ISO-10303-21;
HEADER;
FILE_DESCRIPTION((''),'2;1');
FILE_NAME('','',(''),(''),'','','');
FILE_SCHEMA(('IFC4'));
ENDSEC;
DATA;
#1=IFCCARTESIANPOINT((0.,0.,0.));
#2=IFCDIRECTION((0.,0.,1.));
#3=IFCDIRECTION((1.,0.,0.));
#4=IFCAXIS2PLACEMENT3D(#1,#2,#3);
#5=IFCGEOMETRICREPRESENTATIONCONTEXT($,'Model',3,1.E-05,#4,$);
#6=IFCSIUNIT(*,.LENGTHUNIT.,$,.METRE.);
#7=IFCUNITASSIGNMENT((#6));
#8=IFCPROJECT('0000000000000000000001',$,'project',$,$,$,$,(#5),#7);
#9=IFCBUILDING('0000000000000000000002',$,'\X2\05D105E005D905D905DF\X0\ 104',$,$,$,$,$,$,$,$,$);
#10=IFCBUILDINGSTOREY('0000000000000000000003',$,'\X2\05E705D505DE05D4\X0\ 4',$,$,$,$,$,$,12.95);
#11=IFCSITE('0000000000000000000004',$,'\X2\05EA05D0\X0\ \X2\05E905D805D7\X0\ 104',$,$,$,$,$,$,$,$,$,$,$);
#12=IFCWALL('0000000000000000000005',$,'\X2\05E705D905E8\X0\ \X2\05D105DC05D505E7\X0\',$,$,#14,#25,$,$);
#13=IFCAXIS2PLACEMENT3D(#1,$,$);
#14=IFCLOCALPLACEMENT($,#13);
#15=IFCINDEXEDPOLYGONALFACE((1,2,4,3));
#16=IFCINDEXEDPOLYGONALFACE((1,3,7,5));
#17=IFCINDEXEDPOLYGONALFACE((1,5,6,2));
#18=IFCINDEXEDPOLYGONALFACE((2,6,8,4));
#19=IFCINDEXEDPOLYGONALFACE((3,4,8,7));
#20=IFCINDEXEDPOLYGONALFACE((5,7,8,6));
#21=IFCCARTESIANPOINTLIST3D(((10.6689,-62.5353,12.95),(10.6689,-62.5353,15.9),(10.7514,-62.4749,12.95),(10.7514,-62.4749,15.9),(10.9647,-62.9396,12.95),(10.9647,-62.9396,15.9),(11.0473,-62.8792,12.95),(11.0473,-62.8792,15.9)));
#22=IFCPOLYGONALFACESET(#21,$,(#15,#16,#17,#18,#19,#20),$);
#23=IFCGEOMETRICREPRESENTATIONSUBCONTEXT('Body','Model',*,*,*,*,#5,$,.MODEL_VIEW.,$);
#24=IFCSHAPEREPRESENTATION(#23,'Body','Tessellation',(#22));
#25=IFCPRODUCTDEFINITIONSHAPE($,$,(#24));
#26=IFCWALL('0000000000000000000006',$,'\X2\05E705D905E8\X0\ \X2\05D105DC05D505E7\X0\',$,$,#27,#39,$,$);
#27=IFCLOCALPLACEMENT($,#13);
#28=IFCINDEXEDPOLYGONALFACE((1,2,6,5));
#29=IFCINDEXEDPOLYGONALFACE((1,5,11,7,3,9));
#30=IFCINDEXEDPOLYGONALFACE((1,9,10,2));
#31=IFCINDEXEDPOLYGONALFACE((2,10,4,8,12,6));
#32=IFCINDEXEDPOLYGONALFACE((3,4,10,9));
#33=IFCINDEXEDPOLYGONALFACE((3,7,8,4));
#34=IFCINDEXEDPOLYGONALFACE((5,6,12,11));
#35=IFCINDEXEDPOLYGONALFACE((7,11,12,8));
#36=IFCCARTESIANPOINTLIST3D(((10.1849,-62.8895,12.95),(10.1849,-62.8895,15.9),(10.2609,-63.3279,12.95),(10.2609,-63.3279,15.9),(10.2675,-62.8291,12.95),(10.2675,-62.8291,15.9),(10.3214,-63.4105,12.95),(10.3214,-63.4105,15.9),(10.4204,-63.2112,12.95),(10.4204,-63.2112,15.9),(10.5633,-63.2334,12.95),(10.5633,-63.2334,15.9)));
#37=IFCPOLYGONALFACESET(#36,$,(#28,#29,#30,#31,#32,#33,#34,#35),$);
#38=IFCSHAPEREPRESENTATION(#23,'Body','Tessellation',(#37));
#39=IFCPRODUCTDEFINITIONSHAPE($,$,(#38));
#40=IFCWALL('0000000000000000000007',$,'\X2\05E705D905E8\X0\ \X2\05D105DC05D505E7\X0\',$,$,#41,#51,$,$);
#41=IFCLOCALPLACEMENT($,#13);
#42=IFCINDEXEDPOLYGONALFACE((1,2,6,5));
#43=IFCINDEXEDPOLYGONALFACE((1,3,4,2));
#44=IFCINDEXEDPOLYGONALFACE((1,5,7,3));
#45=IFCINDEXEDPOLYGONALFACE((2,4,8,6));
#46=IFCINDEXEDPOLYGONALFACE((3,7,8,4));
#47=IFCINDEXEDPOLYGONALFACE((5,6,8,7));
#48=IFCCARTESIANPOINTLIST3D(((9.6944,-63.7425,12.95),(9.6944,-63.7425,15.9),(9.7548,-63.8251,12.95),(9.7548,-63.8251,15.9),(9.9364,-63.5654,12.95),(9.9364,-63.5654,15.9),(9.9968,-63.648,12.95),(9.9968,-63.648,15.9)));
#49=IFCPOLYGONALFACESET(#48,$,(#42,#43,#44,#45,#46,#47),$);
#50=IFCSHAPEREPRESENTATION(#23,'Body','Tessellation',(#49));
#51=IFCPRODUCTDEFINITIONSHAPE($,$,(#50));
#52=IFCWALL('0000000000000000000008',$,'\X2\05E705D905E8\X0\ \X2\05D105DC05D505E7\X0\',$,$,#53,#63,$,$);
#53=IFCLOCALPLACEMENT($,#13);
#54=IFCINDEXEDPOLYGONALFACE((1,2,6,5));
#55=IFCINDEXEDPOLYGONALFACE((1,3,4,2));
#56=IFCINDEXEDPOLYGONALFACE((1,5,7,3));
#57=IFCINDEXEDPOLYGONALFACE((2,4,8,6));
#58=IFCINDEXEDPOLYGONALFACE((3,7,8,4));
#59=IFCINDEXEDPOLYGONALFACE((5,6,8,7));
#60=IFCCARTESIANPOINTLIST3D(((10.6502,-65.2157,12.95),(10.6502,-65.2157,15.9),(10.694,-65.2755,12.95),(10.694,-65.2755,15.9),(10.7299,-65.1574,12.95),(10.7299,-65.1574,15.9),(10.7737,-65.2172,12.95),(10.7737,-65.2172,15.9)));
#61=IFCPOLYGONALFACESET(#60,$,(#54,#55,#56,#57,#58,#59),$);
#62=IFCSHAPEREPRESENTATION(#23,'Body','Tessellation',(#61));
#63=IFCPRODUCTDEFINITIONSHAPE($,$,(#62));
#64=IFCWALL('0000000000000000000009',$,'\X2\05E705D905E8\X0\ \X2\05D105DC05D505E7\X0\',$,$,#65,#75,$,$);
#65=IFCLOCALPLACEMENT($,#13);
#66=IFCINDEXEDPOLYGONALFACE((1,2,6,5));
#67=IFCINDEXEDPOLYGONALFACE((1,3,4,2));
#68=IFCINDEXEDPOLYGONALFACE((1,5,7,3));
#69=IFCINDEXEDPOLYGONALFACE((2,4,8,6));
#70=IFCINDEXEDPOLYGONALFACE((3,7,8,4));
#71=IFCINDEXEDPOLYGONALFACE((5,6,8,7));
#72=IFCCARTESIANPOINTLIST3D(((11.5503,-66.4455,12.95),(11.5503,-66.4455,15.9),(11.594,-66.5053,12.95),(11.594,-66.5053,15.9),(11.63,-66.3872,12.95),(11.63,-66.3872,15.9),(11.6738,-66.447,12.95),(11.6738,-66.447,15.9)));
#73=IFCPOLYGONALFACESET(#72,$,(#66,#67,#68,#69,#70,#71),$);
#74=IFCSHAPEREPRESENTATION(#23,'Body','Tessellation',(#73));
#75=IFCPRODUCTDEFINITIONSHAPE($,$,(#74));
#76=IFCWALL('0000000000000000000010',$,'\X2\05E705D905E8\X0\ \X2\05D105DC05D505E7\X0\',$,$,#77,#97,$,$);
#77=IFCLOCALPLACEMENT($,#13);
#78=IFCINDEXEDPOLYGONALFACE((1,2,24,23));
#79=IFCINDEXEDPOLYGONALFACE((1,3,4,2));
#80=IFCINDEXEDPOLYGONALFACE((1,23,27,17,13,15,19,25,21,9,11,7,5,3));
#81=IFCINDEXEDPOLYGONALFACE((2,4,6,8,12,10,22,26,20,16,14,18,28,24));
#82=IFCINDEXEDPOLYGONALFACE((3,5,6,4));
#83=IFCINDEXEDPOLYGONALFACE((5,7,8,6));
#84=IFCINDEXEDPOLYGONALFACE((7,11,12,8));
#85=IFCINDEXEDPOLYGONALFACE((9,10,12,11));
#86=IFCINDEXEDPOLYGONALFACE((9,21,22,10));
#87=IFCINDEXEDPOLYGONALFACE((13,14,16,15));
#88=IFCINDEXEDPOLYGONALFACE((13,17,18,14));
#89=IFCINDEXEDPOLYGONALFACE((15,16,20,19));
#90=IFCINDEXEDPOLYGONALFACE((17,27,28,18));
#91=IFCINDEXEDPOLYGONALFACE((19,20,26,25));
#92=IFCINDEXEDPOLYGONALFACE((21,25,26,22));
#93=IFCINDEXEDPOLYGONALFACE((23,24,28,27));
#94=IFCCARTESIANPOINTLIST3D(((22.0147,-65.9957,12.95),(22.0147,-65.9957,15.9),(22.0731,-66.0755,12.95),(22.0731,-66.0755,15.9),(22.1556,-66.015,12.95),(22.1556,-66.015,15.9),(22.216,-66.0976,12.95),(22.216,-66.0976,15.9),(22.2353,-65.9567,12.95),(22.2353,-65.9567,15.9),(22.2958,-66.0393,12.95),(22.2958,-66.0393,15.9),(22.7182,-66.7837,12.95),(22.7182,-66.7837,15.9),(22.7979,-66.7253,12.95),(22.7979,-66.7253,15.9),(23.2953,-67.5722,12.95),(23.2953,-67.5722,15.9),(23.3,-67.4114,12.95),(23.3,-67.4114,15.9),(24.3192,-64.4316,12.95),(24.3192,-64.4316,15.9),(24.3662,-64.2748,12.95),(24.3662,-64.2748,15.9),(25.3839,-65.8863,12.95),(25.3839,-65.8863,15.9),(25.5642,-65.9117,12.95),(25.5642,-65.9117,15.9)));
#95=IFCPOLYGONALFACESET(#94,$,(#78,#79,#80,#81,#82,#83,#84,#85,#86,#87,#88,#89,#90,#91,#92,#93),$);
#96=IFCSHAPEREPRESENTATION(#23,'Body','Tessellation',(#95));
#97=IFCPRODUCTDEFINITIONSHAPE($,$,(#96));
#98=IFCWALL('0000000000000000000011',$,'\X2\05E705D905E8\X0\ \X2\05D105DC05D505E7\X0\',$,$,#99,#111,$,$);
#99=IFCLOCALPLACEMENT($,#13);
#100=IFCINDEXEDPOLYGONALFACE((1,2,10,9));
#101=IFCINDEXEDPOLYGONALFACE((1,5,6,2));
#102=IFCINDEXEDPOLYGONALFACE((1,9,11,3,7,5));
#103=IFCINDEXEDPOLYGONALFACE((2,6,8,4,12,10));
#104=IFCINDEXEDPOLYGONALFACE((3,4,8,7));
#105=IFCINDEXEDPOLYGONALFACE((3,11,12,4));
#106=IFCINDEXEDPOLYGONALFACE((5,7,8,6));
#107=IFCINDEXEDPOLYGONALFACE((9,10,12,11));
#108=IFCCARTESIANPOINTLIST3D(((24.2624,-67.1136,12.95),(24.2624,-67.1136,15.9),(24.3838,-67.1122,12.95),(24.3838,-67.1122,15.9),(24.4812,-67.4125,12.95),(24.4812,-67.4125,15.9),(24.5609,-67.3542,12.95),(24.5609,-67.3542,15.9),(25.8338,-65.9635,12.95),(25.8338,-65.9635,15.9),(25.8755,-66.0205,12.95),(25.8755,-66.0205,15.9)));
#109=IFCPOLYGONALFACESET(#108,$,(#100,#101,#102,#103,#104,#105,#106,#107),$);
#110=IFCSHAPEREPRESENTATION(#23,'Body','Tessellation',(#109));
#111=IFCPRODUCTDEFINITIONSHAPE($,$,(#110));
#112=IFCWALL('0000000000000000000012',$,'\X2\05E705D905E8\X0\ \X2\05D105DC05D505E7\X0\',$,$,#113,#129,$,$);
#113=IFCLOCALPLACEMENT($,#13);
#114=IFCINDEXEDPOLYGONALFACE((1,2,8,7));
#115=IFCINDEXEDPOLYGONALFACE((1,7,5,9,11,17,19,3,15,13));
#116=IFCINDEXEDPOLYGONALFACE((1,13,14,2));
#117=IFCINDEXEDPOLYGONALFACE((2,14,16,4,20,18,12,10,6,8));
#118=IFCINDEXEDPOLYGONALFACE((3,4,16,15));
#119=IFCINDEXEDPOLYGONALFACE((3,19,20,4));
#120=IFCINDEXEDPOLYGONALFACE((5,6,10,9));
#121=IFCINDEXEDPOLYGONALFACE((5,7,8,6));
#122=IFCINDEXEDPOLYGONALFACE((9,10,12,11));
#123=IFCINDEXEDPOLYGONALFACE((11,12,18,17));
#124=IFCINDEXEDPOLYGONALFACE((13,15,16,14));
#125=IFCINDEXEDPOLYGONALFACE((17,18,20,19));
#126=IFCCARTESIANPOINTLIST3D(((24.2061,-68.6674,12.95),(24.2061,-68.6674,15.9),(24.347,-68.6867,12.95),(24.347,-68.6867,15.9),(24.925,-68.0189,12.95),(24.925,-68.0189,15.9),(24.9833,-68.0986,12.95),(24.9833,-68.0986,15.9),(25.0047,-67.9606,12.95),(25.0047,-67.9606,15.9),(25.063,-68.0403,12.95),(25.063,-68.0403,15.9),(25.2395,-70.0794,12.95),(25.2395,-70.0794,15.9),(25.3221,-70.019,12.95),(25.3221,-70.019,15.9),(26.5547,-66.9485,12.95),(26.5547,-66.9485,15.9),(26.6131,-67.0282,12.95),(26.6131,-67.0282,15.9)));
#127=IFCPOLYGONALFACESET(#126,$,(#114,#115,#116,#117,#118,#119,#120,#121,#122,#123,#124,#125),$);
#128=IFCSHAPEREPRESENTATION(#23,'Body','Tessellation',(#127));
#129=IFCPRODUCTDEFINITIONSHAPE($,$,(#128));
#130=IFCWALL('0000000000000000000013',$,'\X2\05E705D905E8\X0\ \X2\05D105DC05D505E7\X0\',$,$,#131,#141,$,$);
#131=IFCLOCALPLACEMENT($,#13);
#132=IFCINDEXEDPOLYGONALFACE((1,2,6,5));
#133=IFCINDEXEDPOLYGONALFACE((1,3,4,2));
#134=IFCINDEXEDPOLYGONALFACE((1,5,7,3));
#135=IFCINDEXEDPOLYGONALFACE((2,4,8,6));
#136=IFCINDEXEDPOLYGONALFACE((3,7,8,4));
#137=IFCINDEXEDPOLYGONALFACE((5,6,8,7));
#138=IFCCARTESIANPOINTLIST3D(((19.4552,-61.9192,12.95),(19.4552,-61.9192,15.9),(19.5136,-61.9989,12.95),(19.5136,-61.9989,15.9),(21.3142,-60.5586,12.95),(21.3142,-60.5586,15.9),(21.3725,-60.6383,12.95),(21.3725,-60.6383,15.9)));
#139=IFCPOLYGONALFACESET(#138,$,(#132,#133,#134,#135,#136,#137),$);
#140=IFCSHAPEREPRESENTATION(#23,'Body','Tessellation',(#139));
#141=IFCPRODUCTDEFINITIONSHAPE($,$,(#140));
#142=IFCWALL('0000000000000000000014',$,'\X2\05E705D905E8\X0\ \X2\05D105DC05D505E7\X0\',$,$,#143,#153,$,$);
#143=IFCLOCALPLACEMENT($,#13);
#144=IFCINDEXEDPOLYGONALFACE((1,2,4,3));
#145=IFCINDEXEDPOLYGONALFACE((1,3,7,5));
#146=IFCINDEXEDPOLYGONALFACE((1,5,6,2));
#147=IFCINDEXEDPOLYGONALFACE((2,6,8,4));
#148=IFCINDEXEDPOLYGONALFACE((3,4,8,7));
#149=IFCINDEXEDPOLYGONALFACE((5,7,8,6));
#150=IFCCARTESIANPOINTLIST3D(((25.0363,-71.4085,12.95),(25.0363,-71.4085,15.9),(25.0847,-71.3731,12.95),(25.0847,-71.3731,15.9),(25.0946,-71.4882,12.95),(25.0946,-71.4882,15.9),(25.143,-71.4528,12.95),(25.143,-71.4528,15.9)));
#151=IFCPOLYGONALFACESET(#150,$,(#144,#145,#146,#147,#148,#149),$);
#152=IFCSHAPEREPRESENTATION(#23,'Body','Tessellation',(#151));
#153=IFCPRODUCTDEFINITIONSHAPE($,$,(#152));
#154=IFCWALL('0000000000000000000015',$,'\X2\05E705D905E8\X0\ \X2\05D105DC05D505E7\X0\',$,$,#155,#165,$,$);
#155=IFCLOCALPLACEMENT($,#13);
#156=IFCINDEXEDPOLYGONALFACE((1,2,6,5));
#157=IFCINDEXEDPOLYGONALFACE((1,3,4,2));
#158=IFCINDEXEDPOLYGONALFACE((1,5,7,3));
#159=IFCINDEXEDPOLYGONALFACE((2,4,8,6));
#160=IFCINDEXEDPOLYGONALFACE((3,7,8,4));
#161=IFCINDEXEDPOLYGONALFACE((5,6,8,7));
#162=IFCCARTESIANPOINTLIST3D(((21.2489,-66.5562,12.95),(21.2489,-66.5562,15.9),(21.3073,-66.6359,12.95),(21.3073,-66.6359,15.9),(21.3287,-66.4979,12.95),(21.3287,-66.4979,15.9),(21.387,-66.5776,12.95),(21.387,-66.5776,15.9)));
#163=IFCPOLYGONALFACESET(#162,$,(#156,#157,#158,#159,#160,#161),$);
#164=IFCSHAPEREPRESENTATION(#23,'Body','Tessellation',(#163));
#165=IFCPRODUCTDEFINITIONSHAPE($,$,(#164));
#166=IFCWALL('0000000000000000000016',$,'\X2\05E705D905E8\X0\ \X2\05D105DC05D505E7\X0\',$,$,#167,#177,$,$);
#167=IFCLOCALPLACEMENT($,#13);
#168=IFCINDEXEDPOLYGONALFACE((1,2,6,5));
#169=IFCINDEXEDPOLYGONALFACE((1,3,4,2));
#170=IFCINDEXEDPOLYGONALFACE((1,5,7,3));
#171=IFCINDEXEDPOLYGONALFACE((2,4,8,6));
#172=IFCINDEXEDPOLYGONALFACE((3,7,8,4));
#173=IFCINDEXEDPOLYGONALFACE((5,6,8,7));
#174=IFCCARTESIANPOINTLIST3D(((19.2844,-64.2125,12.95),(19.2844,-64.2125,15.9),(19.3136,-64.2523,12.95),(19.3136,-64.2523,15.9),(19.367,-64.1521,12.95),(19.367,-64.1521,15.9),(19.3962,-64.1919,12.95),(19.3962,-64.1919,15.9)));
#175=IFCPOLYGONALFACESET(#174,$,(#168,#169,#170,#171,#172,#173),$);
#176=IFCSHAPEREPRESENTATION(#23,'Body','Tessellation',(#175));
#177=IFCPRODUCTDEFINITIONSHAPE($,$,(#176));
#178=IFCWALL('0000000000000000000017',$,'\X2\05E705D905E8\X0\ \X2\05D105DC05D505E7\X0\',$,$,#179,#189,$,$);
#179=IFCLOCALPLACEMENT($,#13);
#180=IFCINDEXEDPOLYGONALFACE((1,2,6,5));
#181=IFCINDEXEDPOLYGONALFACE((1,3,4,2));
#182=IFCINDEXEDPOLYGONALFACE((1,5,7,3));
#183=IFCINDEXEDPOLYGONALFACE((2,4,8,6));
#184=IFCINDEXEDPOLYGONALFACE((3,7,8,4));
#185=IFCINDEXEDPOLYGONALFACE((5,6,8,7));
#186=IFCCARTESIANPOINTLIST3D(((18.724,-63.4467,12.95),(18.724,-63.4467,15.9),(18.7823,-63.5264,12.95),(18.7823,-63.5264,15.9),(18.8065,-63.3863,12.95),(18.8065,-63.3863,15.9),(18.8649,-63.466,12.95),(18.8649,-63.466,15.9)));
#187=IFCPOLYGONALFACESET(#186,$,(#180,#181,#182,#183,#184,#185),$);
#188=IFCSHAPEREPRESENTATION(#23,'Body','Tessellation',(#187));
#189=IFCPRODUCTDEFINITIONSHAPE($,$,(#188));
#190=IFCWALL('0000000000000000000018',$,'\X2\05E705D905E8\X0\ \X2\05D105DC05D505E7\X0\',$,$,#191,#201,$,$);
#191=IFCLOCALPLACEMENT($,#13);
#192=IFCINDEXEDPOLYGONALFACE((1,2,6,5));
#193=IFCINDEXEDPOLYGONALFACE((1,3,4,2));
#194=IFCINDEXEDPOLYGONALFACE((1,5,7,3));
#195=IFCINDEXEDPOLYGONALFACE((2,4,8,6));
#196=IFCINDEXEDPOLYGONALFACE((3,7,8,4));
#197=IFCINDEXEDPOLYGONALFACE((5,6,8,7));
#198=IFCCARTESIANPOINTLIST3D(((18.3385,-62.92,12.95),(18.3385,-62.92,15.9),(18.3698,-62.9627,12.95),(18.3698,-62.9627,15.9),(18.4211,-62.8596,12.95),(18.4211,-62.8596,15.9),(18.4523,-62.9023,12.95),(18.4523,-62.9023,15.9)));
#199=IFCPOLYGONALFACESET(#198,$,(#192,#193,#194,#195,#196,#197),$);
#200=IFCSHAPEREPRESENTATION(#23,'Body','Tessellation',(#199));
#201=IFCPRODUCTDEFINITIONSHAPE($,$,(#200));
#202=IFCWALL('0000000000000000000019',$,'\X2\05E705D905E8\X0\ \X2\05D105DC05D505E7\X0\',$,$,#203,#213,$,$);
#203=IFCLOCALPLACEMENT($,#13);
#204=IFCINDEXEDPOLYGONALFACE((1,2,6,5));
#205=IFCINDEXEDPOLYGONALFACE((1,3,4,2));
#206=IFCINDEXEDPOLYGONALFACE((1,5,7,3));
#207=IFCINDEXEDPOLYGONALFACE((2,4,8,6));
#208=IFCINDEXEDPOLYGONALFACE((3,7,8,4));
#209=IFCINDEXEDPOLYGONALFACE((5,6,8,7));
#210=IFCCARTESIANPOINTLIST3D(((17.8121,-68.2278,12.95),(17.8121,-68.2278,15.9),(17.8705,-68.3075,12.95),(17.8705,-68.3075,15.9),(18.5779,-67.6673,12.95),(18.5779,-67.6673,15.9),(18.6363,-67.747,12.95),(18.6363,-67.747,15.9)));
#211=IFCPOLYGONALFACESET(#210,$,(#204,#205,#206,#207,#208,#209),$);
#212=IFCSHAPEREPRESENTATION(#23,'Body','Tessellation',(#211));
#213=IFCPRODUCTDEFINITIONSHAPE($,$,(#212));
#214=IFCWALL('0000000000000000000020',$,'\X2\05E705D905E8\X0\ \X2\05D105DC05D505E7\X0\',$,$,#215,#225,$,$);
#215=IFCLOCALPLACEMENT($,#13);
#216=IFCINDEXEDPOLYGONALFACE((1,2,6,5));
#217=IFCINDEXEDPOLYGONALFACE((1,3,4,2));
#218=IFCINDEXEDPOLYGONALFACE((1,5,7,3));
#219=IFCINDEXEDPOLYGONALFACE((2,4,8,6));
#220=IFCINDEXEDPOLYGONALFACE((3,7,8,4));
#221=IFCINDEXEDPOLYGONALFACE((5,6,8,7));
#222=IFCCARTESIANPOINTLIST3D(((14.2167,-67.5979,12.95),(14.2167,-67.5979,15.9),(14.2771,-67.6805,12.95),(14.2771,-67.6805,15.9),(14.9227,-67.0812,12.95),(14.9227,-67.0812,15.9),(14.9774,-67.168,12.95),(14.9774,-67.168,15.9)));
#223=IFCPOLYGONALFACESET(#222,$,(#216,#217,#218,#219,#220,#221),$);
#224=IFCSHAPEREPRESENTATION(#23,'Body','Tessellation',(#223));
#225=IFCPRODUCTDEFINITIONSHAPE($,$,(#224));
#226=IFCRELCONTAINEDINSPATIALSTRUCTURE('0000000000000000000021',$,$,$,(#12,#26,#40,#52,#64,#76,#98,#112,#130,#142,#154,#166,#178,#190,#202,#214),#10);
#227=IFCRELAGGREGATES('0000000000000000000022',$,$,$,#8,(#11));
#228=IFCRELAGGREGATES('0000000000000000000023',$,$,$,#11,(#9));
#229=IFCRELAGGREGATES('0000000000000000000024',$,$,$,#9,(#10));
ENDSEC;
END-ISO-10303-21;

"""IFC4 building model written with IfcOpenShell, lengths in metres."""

from ifc_helpers import new_model, si_unit, frame, origin_with_axes, context, subcontext, project, spatial, polyline, outline, extrude, element, save


model = new_model("IFC4")

# Units and contexts
model_context = context("Model", 3, precision=1e-05, world=origin_with_axes())
body_context = subcontext(model_context, "Body", "Model", "MODEL_VIEW")
ifc_project = project(units=[si_unit("LENGTHUNIT", "METRE")], contexts=[model_context])

# Site, building, storey
site = spatial("IfcSite", under=ifc_project, Name="תא שטח 104")
building = spatial("IfcBuilding", under=site, Name="בניין 104")
storey = spatial("IfcBuildingStorey", under=building, Name="קומה 4", Elevation=12.95)

# Walls
element("IfcWall", 1, inside=storey, Name="קיר בלוק", context=body_context, shape_type="SweptSolid", body=[
    extrude(outline(polyline([(10.6689, -62.5353), (10.9647, -62.9396), (11.0473, -62.8792), (10.7514, -62.4749), (10.6689, -62.5353)])), frame((0.0, 0.0, 12.95)), (0.0, 0.0, 1.0), 2.95),
])
element("IfcWall", 2, inside=storey, Name="קיר בלוק", context=body_context, shape_type="SweptSolid", body=[
    extrude(outline(polyline([(10.2675, -62.8291), (10.1849, -62.8895), (10.4204, -63.2112), (10.2609, -63.3279), (10.3214, -63.4105), (10.5633, -63.2334), (10.2675, -62.8291)])), frame((0.0, 0.0, 12.95)), (0.0, 0.0, 1.0), 2.95),
])
element("IfcWall", 3, inside=storey, Name="קיר בלוק", context=body_context, shape_type="SweptSolid", body=[
    extrude(outline(polyline([(9.9968, -63.648), (9.9364, -63.5654), (9.6944, -63.7425), (9.7548, -63.8251), (9.9968, -63.648)])), frame((0.0, 0.0, 12.95)), (0.0, 0.0, 1.0), 2.95),
])
element("IfcWall", 4, inside=storey, Name="קיר בלוק", context=body_context, shape_type="SweptSolid", body=[
    extrude(outline(polyline([(10.7299, -65.1574), (10.6502, -65.2157), (10.694, -65.2755), (10.7737, -65.2172), (10.7299, -65.1574)])), frame((0.0, 0.0, 12.95)), (0.0, 0.0, 1.0), 2.95),
])
element("IfcWall", 5, inside=storey, Name="קיר בלוק", context=body_context, shape_type="SweptSolid", body=[
    extrude(outline(polyline([(11.6738, -66.447), (11.63, -66.3872), (11.5503, -66.4455), (11.594, -66.5053), (11.6738, -66.447)])), frame((0.0, 0.0, 12.95)), (0.0, 0.0, 1.0), 2.95),
])
element("IfcWall", 6, inside=storey, Name="קיר בלוק", context=body_context, shape_type="SweptSolid", body=[
    extrude(outline(polyline([(22.7182, -66.7837), (23.2953, -67.5722), (25.5642, -65.9117), (24.3662, -64.2748), (22.0147, -65.9957), (22.0731, -66.0755), (22.1556, -66.015), (22.216, -66.0976), (22.2958, -66.0393), (22.2353, -65.9567), (24.3192, -64.4316), (25.3839, -65.8863), (23.3, -67.4114), (22.7979, -66.7253), (22.7182, -66.7837)])), frame((0.0, 0.0, 12.95)), (0.0, 0.0, 1.0), 2.95),
])
element("IfcWall", 7, inside=storey, Name="קיר בלוק", context=body_context, shape_type="SweptSolid", body=[
    extrude(outline(polyline([(24.2624, -67.1136), (24.4812, -67.4125), (24.5609, -67.3542), (24.3838, -67.1122), (25.8755, -66.0205), (25.8338, -65.9635), (24.2624, -67.1136)])), frame((0.0, 0.0, 12.95)), (0.0, 0.0, 1.0), 2.95),
])
element("IfcWall", 8, inside=storey, Name="קיר בלוק", context=body_context, shape_type="SweptSolid", body=[
    extrude(outline(polyline([(24.925, -68.0189), (24.9833, -68.0986), (24.2061, -68.6674), (25.2395, -70.0794), (25.3221, -70.019), (24.347, -68.6867), (26.6131, -67.0282), (26.5547, -66.9485), (25.063, -68.0403), (25.0047, -67.9606), (24.925, -68.0189)])), frame((0.0, 0.0, 12.95)), (0.0, 0.0, 1.0), 2.95),
])
element("IfcWall", 9, inside=storey, Name="קיר בלוק", context=body_context, shape_type="SweptSolid", body=[
    extrude(outline(polyline([(21.3142, -60.5586), (19.4552, -61.9192), (19.5136, -61.9989), (21.3725, -60.6383), (21.3142, -60.5586)])), frame((0.0, 0.0, 12.95)), (0.0, 0.0, 1.0), 2.95),
])
element("IfcWall", 10, inside=storey, Name="קיר בלוק", context=body_context, shape_type="SweptSolid", body=[
    extrude(outline(polyline([(25.0946, -71.4882), (25.143, -71.4528), (25.0847, -71.3731), (25.0363, -71.4085), (25.0946, -71.4882)])), frame((0.0, 0.0, 12.95)), (0.0, 0.0, 1.0), 2.95),
])
element("IfcWall", 11, inside=storey, Name="קיר בלוק", context=body_context, shape_type="SweptSolid", body=[
    extrude(outline(polyline([(21.387, -66.5776), (21.3287, -66.4979), (21.2489, -66.5562), (21.3073, -66.6359), (21.387, -66.5776)])), frame((0.0, 0.0, 12.95)), (0.0, 0.0, 1.0), 2.95),
])
element("IfcWall", 12, inside=storey, Name="קיר בלוק", context=body_context, shape_type="SweptSolid", body=[
    extrude(outline(polyline([(19.2844, -64.2125), (19.3136, -64.2523), (19.3962, -64.1919), (19.367, -64.1521), (19.2844, -64.2125)])), frame((0.0, 0.0, 12.95)), (0.0, 0.0, 1.0), 2.95),
])
element("IfcWall", 13, inside=storey, Name="קיר בלוק", context=body_context, shape_type="SweptSolid", body=[
    extrude(outline(polyline([(18.8065, -63.3863), (18.724, -63.4467), (18.7823, -63.5264), (18.8649, -63.466), (18.8065, -63.3863)])), frame((0.0, 0.0, 12.95)), (0.0, 0.0, 1.0), 2.95),
])
element("IfcWall", 14, inside=storey, Name="קיר בלוק", context=body_context, shape_type="SweptSolid", body=[
    extrude(outline(polyline([(18.4523, -62.9023), (18.4211, -62.8596), (18.3385, -62.92), (18.3698, -62.9627), (18.4523, -62.9023)])), frame((0.0, 0.0, 12.95)), (0.0, 0.0, 1.0), 2.95),
])
element("IfcWall", 15, inside=storey, Name="קיר בלוק", context=body_context, shape_type="SweptSolid", body=[
    extrude(outline(polyline([(17.8121, -68.2278), (17.8705, -68.3075), (18.6363, -67.747), (18.5779, -67.6673), (17.8121, -68.2278)])), frame((0.0, 0.0, 12.95)), (0.0, 0.0, 1.0), 2.95),
])
element("IfcWall", 16, inside=storey, Name="קיר בלוק", context=body_context, shape_type="SweptSolid", body=[
    extrude(outline(polyline([(14.9227, -67.0812), (14.2167, -67.5979), (14.2771, -67.6805), (14.9774, -67.168), (14.9227, -67.0812)])), frame((0.0, 0.0, 12.95)), (0.0, 0.0, 1.0), 2.95),
])

save(model, "model.ifc")
